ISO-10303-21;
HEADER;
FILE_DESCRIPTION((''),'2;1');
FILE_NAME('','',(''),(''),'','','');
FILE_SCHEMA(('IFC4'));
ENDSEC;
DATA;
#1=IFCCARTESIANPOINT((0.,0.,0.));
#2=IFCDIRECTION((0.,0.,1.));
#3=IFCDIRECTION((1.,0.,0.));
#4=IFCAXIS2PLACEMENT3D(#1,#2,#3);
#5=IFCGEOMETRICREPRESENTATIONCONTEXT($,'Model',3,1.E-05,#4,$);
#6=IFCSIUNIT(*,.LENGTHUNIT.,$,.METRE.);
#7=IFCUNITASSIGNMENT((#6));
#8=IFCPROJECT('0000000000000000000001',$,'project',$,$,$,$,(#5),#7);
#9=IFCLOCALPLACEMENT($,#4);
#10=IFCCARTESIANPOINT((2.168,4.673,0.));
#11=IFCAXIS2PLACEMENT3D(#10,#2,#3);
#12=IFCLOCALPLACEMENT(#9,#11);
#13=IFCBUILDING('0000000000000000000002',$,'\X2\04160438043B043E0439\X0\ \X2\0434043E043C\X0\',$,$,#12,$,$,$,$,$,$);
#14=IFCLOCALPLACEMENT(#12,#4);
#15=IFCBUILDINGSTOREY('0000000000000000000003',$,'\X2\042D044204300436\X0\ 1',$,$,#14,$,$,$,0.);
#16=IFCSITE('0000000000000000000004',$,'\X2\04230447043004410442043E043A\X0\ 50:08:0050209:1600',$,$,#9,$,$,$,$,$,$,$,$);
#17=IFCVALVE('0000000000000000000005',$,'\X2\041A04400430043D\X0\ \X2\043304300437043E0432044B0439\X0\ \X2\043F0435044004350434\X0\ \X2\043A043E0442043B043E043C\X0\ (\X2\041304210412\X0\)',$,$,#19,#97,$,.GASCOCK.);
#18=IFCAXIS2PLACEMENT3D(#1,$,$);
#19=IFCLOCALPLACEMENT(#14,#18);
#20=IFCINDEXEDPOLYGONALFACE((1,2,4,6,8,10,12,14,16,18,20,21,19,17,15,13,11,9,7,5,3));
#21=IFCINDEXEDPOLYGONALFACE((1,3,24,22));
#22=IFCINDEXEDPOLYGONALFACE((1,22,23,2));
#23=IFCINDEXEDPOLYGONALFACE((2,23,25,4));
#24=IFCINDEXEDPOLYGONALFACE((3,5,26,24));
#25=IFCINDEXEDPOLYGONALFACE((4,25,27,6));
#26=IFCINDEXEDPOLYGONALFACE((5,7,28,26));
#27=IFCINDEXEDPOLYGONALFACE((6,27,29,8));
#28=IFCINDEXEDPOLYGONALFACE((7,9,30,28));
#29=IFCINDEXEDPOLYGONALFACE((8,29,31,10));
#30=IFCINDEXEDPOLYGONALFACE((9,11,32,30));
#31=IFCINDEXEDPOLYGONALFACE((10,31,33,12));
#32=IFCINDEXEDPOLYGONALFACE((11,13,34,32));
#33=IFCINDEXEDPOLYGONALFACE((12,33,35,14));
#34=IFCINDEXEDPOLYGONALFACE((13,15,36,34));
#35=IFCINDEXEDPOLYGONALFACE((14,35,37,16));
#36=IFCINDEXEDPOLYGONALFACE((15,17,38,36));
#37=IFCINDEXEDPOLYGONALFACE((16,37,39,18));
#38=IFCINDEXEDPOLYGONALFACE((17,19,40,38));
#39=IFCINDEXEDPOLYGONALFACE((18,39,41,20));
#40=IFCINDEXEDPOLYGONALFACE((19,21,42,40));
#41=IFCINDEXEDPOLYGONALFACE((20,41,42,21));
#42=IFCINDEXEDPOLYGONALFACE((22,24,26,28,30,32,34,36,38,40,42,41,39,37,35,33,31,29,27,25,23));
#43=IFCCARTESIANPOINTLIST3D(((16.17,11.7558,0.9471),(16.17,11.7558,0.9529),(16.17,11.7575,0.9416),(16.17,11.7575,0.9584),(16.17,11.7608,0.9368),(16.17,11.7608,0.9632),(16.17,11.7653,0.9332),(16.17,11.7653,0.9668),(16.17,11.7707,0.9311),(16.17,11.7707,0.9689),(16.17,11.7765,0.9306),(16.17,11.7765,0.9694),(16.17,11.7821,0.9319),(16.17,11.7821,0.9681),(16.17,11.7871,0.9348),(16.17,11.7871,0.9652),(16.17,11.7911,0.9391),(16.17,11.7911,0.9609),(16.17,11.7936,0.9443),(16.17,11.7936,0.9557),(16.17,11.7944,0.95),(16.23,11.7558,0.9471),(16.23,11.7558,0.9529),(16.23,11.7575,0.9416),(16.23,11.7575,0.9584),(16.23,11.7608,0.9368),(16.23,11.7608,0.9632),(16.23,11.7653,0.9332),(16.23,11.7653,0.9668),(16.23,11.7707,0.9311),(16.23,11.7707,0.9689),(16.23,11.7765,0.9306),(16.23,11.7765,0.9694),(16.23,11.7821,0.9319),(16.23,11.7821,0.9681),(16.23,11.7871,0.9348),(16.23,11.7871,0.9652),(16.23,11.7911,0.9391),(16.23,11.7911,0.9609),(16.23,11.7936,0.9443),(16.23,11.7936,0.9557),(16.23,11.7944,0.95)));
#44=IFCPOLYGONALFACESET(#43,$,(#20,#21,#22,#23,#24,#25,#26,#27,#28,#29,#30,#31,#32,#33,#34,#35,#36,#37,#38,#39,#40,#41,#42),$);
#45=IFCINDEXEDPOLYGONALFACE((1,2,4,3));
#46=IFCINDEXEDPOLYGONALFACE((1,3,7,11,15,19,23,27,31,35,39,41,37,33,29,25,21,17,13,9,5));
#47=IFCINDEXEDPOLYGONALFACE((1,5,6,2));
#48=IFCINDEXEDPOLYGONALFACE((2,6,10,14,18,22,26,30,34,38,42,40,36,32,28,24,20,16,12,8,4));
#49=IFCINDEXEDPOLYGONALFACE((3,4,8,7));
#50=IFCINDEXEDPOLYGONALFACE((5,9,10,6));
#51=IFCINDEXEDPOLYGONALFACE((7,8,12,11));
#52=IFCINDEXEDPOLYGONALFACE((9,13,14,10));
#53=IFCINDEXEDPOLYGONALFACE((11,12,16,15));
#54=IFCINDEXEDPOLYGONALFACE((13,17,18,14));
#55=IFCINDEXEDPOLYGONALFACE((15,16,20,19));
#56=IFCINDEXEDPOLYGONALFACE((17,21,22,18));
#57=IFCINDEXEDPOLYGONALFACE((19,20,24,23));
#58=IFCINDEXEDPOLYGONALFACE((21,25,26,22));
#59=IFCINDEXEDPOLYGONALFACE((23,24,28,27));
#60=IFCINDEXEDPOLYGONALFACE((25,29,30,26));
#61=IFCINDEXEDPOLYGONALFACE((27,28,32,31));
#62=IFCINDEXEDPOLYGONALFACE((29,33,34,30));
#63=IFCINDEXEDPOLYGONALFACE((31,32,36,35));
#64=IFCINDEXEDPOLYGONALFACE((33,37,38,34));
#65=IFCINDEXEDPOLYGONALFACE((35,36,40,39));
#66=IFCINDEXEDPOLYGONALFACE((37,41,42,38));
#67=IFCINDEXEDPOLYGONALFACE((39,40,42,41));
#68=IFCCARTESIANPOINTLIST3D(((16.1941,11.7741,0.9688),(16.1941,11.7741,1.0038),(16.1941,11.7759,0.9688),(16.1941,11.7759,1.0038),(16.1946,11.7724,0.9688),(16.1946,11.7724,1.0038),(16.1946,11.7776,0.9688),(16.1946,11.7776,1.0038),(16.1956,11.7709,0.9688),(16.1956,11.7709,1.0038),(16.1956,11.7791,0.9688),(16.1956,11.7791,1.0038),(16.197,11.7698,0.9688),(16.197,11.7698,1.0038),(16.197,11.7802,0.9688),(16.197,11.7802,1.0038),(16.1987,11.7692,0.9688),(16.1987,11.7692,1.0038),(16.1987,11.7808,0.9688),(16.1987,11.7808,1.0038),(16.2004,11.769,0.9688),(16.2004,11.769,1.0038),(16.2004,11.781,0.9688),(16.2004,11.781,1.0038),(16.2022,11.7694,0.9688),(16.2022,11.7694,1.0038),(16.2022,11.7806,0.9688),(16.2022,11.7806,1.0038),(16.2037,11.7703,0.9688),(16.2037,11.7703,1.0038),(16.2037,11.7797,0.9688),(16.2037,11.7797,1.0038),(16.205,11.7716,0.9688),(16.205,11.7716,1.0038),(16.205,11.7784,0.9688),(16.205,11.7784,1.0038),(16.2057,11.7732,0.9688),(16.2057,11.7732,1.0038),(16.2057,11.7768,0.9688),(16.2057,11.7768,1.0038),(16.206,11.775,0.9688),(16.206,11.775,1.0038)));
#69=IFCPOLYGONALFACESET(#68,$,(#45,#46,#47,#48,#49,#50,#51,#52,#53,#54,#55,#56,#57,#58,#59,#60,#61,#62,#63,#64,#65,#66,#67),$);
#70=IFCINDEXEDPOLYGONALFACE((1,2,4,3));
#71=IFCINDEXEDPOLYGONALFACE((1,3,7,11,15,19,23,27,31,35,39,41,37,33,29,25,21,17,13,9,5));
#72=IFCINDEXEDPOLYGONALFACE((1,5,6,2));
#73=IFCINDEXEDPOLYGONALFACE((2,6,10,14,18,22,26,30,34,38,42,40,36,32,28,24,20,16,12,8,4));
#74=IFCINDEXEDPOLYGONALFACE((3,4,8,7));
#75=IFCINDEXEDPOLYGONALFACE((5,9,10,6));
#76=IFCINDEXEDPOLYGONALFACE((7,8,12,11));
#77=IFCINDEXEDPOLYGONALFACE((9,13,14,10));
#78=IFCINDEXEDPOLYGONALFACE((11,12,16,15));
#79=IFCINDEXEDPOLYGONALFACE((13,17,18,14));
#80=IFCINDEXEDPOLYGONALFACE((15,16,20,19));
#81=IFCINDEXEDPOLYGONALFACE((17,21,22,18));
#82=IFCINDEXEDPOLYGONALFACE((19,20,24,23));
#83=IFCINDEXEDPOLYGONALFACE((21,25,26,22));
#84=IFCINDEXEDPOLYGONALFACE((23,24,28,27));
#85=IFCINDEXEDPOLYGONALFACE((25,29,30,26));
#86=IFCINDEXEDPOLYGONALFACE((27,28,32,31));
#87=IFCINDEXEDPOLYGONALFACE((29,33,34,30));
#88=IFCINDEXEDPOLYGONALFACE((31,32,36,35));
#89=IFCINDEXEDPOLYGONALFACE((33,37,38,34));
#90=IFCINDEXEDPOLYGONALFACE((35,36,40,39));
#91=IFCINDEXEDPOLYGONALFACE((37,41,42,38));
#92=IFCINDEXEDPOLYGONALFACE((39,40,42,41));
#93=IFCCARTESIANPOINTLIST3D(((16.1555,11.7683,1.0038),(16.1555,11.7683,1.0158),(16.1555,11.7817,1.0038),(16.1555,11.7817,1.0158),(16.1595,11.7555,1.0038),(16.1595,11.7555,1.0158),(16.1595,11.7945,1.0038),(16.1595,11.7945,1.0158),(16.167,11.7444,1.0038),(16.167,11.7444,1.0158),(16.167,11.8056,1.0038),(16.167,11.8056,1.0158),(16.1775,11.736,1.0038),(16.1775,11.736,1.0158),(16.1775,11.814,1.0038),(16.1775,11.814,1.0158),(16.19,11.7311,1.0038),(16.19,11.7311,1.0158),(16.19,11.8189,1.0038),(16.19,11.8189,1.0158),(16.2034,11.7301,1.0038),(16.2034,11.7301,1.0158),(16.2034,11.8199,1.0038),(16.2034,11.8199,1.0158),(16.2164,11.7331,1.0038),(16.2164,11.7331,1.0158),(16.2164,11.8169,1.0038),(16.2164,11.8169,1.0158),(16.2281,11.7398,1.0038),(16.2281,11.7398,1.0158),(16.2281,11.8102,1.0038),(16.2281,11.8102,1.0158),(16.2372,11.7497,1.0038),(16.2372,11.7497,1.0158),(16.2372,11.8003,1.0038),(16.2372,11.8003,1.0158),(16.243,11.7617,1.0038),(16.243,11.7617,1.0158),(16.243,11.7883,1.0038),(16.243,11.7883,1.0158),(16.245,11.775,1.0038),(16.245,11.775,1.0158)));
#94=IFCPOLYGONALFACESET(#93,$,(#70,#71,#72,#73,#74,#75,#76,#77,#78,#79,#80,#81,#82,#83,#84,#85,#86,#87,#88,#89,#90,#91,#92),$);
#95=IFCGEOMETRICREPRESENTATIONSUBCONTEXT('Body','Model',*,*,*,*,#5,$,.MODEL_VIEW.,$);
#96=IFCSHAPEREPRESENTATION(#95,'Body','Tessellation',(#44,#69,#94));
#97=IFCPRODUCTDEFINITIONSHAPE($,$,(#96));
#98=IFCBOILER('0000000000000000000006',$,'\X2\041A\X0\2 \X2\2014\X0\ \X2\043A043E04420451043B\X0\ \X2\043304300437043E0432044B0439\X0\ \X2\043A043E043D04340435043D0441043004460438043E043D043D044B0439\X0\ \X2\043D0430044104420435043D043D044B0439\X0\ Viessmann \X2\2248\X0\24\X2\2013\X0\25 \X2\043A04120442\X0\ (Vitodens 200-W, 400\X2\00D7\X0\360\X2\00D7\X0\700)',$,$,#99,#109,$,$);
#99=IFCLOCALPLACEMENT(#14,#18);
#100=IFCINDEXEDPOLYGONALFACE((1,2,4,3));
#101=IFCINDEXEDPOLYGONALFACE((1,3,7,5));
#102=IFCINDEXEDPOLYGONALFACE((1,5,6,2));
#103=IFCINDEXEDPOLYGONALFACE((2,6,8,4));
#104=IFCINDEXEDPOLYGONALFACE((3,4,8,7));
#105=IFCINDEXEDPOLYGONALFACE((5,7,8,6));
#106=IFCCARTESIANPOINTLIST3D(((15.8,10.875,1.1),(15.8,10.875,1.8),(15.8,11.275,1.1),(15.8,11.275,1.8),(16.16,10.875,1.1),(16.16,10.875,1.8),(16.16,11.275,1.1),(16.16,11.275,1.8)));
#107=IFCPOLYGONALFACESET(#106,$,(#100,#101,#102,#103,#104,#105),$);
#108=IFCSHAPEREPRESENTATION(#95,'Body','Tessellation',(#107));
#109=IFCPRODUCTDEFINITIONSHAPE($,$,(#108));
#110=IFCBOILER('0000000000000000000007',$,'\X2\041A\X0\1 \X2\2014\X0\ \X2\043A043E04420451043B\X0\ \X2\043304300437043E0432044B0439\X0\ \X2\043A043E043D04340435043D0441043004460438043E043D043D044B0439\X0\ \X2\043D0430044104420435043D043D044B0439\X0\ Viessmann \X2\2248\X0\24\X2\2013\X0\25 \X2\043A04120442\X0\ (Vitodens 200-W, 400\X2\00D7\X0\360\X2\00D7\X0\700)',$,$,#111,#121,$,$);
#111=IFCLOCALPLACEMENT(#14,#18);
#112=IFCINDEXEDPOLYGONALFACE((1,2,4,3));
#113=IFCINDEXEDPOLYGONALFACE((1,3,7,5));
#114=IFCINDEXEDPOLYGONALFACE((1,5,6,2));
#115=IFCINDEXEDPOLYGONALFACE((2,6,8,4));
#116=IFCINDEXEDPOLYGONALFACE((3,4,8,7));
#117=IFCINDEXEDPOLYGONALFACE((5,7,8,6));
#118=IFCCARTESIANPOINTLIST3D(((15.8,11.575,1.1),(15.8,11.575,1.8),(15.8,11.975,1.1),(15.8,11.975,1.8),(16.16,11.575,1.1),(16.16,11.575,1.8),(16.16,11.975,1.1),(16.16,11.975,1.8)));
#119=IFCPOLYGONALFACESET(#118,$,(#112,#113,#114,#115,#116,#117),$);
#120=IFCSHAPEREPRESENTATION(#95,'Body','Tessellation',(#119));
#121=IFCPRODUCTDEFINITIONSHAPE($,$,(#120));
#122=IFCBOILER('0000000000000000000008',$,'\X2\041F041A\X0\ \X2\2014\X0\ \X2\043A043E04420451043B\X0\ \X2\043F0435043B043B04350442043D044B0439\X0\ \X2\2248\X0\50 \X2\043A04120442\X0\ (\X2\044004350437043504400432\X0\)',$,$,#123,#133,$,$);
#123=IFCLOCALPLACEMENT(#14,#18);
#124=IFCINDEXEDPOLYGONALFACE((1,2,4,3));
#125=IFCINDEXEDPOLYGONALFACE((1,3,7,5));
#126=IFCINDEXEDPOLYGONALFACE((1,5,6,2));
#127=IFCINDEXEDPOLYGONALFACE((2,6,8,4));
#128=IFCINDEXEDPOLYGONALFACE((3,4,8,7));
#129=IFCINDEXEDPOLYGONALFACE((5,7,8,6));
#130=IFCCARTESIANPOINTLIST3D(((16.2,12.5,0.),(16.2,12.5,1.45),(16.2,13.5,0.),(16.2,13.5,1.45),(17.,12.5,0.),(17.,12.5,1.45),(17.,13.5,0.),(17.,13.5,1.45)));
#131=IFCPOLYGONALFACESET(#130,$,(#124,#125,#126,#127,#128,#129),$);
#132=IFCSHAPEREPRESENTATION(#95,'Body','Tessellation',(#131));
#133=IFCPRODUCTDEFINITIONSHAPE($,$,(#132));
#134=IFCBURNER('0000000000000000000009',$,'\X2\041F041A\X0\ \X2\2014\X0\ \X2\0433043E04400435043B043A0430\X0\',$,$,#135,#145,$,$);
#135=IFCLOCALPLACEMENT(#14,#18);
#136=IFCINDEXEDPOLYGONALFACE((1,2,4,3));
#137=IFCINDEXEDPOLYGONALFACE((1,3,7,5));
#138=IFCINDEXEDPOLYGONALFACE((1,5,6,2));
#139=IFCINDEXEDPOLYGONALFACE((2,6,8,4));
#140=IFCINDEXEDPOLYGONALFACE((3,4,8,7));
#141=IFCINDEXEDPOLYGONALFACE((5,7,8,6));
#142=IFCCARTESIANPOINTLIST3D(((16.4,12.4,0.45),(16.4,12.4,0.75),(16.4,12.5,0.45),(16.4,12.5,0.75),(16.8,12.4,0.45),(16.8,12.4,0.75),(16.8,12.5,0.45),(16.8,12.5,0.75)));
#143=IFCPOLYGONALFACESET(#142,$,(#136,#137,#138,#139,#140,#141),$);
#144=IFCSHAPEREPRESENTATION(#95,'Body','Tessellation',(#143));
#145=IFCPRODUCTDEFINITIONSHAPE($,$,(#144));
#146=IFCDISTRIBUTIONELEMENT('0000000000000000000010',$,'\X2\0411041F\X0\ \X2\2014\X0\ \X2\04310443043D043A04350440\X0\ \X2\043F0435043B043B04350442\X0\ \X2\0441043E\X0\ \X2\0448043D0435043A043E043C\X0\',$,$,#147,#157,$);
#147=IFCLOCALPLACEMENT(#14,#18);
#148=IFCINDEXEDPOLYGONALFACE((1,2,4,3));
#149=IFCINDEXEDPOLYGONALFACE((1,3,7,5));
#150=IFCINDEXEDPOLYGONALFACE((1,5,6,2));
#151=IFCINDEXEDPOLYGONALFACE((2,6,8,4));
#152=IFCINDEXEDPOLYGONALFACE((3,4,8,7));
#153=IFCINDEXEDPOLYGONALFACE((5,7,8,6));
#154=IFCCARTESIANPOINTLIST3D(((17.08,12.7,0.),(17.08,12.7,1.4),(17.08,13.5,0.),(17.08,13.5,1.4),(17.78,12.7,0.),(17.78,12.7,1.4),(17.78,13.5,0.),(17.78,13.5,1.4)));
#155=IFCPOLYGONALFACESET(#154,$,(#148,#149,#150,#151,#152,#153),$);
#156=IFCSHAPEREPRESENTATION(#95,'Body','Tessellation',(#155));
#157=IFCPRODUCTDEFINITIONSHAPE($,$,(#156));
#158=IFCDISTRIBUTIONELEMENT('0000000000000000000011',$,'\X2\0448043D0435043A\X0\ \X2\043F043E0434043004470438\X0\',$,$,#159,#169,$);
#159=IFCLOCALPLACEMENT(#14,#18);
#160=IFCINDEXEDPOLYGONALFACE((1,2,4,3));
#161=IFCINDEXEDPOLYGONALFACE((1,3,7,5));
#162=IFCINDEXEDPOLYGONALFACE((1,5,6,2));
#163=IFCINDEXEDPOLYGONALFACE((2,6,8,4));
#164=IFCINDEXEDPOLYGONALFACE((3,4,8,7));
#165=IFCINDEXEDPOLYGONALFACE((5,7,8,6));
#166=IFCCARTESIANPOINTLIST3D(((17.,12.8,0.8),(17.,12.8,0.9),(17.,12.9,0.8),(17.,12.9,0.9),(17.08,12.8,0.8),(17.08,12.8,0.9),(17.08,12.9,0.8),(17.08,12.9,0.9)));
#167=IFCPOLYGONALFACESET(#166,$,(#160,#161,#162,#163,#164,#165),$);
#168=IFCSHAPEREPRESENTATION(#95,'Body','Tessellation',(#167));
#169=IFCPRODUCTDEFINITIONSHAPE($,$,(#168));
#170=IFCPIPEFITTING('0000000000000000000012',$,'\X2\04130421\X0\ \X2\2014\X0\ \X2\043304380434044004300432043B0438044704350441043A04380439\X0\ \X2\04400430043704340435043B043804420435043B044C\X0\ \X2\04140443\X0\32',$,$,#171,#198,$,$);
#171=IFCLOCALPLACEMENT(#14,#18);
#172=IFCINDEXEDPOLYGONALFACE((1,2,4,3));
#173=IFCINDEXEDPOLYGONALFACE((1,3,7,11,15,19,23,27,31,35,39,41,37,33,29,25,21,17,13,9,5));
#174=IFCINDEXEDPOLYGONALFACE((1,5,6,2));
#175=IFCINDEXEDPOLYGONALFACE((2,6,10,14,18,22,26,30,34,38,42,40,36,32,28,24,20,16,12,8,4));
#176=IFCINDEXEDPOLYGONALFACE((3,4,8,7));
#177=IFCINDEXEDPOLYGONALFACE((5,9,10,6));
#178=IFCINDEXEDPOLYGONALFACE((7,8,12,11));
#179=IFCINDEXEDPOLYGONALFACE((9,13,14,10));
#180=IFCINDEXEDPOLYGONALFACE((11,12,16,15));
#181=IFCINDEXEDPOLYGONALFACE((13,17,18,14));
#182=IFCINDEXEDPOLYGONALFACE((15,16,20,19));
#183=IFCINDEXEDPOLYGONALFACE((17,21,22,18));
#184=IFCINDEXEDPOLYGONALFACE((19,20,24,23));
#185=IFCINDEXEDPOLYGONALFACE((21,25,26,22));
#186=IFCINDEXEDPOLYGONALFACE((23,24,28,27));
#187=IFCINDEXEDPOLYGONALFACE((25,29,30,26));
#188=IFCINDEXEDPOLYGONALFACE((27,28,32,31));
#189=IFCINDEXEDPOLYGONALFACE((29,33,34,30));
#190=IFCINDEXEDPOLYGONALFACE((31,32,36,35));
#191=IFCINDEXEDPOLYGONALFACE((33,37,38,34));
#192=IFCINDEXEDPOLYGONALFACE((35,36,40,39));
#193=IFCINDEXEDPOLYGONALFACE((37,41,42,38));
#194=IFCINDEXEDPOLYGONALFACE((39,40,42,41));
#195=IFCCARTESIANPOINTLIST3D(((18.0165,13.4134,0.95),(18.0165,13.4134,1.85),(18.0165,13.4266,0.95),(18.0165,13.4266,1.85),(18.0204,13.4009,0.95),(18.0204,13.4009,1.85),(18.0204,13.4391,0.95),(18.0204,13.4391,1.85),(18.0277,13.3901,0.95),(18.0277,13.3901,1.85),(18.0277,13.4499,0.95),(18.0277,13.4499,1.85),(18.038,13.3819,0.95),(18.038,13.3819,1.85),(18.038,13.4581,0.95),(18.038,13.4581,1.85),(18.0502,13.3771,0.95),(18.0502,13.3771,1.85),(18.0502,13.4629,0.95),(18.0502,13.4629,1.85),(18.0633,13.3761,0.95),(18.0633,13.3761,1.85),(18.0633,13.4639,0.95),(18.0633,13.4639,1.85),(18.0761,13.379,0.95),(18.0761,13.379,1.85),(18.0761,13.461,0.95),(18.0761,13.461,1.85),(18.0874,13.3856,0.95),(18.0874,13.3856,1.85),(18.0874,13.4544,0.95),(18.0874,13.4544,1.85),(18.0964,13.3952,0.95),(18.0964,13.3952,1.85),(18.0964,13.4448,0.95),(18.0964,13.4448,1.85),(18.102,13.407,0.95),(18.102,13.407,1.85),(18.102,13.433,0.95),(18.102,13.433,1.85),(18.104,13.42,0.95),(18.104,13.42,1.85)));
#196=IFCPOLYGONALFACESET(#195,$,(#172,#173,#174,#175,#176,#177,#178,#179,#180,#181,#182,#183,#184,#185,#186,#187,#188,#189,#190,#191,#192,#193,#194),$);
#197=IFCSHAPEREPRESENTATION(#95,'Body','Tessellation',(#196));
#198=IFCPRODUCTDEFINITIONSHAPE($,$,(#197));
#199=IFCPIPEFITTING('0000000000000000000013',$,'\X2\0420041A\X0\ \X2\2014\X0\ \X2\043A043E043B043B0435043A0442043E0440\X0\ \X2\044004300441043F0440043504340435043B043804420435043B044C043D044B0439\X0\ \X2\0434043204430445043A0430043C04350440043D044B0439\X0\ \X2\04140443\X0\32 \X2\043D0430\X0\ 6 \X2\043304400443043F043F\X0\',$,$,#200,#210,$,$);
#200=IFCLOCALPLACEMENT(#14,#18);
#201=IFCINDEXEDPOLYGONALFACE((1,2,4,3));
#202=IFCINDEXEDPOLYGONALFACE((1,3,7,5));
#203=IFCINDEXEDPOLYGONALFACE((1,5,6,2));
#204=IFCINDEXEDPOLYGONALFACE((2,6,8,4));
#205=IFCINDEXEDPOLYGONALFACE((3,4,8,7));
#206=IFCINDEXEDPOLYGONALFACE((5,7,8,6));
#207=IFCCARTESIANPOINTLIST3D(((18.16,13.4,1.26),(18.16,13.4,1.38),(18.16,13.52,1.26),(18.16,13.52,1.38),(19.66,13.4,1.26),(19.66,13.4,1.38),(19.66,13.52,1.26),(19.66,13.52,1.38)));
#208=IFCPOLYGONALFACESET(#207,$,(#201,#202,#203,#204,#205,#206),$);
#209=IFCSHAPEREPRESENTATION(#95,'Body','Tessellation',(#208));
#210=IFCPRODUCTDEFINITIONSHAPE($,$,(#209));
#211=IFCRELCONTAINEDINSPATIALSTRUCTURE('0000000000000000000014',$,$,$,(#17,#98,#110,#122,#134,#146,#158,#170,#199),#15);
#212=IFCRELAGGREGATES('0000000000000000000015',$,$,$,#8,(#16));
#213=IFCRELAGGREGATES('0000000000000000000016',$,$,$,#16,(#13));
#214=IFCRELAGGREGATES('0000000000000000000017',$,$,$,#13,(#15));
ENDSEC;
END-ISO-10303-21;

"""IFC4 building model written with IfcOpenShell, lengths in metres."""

from ifc_helpers import new_model, si_unit, frame, frame_2d, origin_with_axes, origin_2d, place, context, subcontext, project, spatial, rectangle, circle, extrude, element, save


model = new_model("IFC4")

# Units and contexts
model_context = context("Model", 3, precision=1e-05, world=origin_with_axes())
body_context = subcontext(model_context, "Body", "Model", "MODEL_VIEW")
ifc_project = project(units=[si_unit("LENGTHUNIT", "METRE")], contexts=[model_context])

# Site, building, storey
site_placement = place(None, origin_with_axes())
site = spatial("IfcSite", under=ifc_project, at=site_placement, Name="Участок 50:08:0050209:1600")
building_placement = place(site_placement, frame((2.168, 4.673, 0.0), z_axis=(0.0, 0.0, 1.0), x_axis=(1.0, 0.0, 0.0)))
building = spatial("IfcBuilding", under=site, at=building_placement, Name="Жилой дом")
storey_placement = place(building_placement, origin_with_axes())
storey = spatial("IfcBuildingStorey", under=building, at=storey_placement, Name="Этаж 1", Elevation=0.0)

# Valve
valve_1_placement = place(storey_placement, origin_with_axes())
element("IfcValve", 1, at=valve_1_placement, inside=storey, Name="Кран газовый перед котлом (ГСВ)", PredefinedType="GASCOCK", context=body_context, shape_type="SweptSolid", body=[
    extrude(circle(Radius=0.0194, at=origin_2d()), frame((16.17, 11.775, 0.95), z_axis=(1.0, 0.0, 0.0), x_axis=(0.0, 1.0, 0.0)), (0.0, 0.0, 1.0), 0.06),
    extrude(circle(Radius=0.006, at=origin_2d()), frame((16.2, 11.775, 0.9688), z_axis=(0.0, 0.0, 1.0), x_axis=(1.0, 0.0, 0.0)), (0.0, 0.0, 1.0), 0.035),
    extrude(circle(Radius=0.045, at=origin_2d()), frame((16.2, 11.775, 1.0038), z_axis=(0.0, 0.0, 1.0), x_axis=(1.0, 0.0, 0.0)), (0.0, 0.0, 1.0), 0.012),
])

# Boilers
boiler_1_placement = place(storey_placement, origin_with_axes())
element("IfcBoiler", 2, at=boiler_1_placement, inside=storey, Name="К2 — котёл газовый конденсационный настенный Viessmann ≈24–25 кВт (Vitodens 200-W, 400×360×700)", context=body_context, shape_type="SweptSolid", body=[
    extrude(rectangle(XDim=0.36, YDim=0.4, at=frame_2d((0.18, 0.2))), frame((15.8, 10.875, 1.1), z_axis=(0.0, 0.0, 1.0), x_axis=(1.0, 0.0, 0.0)), (0.0, 0.0, 1.0), 0.7),
])
boiler_2_placement = place(storey_placement, origin_with_axes())
element("IfcBoiler", 3, at=boiler_2_placement, inside=storey, Name="К1 — котёл газовый конденсационный настенный Viessmann ≈24–25 кВт (Vitodens 200-W, 400×360×700)", context=body_context, shape_type="SweptSolid", body=[
    extrude(rectangle(XDim=0.36, YDim=0.4, at=frame_2d((0.18, 0.2))), frame((15.8, 11.575, 1.1), z_axis=(0.0, 0.0, 1.0), x_axis=(1.0, 0.0, 0.0)), (0.0, 0.0, 1.0), 0.7),
])
boiler_3_placement = place(storey_placement, origin_with_axes())
element("IfcBoiler", 4, at=boiler_3_placement, inside=storey, Name="ПК — котёл пеллетный ≈50 кВт (резерв)", context=body_context, shape_type="SweptSolid", body=[
    extrude(rectangle(XDim=0.8, YDim=1.0, at=frame_2d((0.4, 0.5))), frame((16.2, 12.5, 0.0), z_axis=(0.0, 0.0, 1.0), x_axis=(1.0, 0.0, 0.0)), (0.0, 0.0, 1.0), 1.45),
])

# Burner
burner_placement = place(storey_placement, origin_with_axes())
element("IfcBurner", 5, at=burner_placement, inside=storey, Name="ПК — горелка", context=body_context, shape_type="SweptSolid", body=[
    extrude(rectangle(XDim=0.4, YDim=0.1, at=frame_2d((0.2, 0.05))), frame((16.4, 12.4, 0.45), z_axis=(0.0, 0.0, 1.0), x_axis=(1.0, 0.0, 0.0)), (0.0, 0.0, 1.0), 0.3),
])

# Distribution elements
distribution_element_1_placement = place(storey_placement, origin_with_axes())
element("IfcDistributionElement", 6, at=distribution_element_1_placement, inside=storey, Name="БП — бункер пеллет со шнеком", context=body_context, shape_type="SweptSolid", body=[
    extrude(rectangle(XDim=0.7, YDim=0.8, at=frame_2d((0.35, 0.4))), frame((17.08, 12.7, 0.0), z_axis=(0.0, 0.0, 1.0), x_axis=(1.0, 0.0, 0.0)), (0.0, 0.0, 1.0), 1.4),
])
distribution_element_2_placement = place(storey_placement, origin_with_axes())
element("IfcDistributionElement", 7, at=distribution_element_2_placement, inside=storey, Name="шнек подачи", context=body_context, shape_type="SweptSolid", body=[
    extrude(rectangle(XDim=0.08, YDim=0.1, at=frame_2d((0.04, 0.05))), frame((17.0, 12.8, 0.8), z_axis=(0.0, 0.0, 1.0), x_axis=(1.0, 0.0, 0.0)), (0.0, 0.0, 1.0), 0.1),
])

# Pipe fittings
pipe_fitting_1_placement = place(storey_placement, origin_with_axes())
element("IfcPipeFitting", 8, at=pipe_fitting_1_placement, inside=storey, Name="ГС — гидравлический разделитель Ду32", context=body_context, shape_type="SweptSolid", body=[
    extrude(circle(Radius=0.044, at=origin_2d()), frame((18.06, 13.42, 0.95), z_axis=(0.0, 0.0, 1.0), x_axis=(1.0, 0.0, 0.0)), (0.0, 0.0, 1.0), 0.9),
])
pipe_fitting_2_placement = place(storey_placement, origin_with_axes())
element("IfcPipeFitting", 9, at=pipe_fitting_2_placement, inside=storey, Name="РК — коллектор распределительный двухкамерный Ду32 на 6 групп", context=body_context, shape_type="SweptSolid", body=[
    extrude(rectangle(XDim=1.5, YDim=0.12, at=frame_2d((0.75, 0.06))), frame((18.16, 13.4, 1.26), z_axis=(0.0, 0.0, 1.0), x_axis=(1.0, 0.0, 0.0)), (0.0, 0.0, 1.0), 0.12),
])

save(model, "model.ifc")
